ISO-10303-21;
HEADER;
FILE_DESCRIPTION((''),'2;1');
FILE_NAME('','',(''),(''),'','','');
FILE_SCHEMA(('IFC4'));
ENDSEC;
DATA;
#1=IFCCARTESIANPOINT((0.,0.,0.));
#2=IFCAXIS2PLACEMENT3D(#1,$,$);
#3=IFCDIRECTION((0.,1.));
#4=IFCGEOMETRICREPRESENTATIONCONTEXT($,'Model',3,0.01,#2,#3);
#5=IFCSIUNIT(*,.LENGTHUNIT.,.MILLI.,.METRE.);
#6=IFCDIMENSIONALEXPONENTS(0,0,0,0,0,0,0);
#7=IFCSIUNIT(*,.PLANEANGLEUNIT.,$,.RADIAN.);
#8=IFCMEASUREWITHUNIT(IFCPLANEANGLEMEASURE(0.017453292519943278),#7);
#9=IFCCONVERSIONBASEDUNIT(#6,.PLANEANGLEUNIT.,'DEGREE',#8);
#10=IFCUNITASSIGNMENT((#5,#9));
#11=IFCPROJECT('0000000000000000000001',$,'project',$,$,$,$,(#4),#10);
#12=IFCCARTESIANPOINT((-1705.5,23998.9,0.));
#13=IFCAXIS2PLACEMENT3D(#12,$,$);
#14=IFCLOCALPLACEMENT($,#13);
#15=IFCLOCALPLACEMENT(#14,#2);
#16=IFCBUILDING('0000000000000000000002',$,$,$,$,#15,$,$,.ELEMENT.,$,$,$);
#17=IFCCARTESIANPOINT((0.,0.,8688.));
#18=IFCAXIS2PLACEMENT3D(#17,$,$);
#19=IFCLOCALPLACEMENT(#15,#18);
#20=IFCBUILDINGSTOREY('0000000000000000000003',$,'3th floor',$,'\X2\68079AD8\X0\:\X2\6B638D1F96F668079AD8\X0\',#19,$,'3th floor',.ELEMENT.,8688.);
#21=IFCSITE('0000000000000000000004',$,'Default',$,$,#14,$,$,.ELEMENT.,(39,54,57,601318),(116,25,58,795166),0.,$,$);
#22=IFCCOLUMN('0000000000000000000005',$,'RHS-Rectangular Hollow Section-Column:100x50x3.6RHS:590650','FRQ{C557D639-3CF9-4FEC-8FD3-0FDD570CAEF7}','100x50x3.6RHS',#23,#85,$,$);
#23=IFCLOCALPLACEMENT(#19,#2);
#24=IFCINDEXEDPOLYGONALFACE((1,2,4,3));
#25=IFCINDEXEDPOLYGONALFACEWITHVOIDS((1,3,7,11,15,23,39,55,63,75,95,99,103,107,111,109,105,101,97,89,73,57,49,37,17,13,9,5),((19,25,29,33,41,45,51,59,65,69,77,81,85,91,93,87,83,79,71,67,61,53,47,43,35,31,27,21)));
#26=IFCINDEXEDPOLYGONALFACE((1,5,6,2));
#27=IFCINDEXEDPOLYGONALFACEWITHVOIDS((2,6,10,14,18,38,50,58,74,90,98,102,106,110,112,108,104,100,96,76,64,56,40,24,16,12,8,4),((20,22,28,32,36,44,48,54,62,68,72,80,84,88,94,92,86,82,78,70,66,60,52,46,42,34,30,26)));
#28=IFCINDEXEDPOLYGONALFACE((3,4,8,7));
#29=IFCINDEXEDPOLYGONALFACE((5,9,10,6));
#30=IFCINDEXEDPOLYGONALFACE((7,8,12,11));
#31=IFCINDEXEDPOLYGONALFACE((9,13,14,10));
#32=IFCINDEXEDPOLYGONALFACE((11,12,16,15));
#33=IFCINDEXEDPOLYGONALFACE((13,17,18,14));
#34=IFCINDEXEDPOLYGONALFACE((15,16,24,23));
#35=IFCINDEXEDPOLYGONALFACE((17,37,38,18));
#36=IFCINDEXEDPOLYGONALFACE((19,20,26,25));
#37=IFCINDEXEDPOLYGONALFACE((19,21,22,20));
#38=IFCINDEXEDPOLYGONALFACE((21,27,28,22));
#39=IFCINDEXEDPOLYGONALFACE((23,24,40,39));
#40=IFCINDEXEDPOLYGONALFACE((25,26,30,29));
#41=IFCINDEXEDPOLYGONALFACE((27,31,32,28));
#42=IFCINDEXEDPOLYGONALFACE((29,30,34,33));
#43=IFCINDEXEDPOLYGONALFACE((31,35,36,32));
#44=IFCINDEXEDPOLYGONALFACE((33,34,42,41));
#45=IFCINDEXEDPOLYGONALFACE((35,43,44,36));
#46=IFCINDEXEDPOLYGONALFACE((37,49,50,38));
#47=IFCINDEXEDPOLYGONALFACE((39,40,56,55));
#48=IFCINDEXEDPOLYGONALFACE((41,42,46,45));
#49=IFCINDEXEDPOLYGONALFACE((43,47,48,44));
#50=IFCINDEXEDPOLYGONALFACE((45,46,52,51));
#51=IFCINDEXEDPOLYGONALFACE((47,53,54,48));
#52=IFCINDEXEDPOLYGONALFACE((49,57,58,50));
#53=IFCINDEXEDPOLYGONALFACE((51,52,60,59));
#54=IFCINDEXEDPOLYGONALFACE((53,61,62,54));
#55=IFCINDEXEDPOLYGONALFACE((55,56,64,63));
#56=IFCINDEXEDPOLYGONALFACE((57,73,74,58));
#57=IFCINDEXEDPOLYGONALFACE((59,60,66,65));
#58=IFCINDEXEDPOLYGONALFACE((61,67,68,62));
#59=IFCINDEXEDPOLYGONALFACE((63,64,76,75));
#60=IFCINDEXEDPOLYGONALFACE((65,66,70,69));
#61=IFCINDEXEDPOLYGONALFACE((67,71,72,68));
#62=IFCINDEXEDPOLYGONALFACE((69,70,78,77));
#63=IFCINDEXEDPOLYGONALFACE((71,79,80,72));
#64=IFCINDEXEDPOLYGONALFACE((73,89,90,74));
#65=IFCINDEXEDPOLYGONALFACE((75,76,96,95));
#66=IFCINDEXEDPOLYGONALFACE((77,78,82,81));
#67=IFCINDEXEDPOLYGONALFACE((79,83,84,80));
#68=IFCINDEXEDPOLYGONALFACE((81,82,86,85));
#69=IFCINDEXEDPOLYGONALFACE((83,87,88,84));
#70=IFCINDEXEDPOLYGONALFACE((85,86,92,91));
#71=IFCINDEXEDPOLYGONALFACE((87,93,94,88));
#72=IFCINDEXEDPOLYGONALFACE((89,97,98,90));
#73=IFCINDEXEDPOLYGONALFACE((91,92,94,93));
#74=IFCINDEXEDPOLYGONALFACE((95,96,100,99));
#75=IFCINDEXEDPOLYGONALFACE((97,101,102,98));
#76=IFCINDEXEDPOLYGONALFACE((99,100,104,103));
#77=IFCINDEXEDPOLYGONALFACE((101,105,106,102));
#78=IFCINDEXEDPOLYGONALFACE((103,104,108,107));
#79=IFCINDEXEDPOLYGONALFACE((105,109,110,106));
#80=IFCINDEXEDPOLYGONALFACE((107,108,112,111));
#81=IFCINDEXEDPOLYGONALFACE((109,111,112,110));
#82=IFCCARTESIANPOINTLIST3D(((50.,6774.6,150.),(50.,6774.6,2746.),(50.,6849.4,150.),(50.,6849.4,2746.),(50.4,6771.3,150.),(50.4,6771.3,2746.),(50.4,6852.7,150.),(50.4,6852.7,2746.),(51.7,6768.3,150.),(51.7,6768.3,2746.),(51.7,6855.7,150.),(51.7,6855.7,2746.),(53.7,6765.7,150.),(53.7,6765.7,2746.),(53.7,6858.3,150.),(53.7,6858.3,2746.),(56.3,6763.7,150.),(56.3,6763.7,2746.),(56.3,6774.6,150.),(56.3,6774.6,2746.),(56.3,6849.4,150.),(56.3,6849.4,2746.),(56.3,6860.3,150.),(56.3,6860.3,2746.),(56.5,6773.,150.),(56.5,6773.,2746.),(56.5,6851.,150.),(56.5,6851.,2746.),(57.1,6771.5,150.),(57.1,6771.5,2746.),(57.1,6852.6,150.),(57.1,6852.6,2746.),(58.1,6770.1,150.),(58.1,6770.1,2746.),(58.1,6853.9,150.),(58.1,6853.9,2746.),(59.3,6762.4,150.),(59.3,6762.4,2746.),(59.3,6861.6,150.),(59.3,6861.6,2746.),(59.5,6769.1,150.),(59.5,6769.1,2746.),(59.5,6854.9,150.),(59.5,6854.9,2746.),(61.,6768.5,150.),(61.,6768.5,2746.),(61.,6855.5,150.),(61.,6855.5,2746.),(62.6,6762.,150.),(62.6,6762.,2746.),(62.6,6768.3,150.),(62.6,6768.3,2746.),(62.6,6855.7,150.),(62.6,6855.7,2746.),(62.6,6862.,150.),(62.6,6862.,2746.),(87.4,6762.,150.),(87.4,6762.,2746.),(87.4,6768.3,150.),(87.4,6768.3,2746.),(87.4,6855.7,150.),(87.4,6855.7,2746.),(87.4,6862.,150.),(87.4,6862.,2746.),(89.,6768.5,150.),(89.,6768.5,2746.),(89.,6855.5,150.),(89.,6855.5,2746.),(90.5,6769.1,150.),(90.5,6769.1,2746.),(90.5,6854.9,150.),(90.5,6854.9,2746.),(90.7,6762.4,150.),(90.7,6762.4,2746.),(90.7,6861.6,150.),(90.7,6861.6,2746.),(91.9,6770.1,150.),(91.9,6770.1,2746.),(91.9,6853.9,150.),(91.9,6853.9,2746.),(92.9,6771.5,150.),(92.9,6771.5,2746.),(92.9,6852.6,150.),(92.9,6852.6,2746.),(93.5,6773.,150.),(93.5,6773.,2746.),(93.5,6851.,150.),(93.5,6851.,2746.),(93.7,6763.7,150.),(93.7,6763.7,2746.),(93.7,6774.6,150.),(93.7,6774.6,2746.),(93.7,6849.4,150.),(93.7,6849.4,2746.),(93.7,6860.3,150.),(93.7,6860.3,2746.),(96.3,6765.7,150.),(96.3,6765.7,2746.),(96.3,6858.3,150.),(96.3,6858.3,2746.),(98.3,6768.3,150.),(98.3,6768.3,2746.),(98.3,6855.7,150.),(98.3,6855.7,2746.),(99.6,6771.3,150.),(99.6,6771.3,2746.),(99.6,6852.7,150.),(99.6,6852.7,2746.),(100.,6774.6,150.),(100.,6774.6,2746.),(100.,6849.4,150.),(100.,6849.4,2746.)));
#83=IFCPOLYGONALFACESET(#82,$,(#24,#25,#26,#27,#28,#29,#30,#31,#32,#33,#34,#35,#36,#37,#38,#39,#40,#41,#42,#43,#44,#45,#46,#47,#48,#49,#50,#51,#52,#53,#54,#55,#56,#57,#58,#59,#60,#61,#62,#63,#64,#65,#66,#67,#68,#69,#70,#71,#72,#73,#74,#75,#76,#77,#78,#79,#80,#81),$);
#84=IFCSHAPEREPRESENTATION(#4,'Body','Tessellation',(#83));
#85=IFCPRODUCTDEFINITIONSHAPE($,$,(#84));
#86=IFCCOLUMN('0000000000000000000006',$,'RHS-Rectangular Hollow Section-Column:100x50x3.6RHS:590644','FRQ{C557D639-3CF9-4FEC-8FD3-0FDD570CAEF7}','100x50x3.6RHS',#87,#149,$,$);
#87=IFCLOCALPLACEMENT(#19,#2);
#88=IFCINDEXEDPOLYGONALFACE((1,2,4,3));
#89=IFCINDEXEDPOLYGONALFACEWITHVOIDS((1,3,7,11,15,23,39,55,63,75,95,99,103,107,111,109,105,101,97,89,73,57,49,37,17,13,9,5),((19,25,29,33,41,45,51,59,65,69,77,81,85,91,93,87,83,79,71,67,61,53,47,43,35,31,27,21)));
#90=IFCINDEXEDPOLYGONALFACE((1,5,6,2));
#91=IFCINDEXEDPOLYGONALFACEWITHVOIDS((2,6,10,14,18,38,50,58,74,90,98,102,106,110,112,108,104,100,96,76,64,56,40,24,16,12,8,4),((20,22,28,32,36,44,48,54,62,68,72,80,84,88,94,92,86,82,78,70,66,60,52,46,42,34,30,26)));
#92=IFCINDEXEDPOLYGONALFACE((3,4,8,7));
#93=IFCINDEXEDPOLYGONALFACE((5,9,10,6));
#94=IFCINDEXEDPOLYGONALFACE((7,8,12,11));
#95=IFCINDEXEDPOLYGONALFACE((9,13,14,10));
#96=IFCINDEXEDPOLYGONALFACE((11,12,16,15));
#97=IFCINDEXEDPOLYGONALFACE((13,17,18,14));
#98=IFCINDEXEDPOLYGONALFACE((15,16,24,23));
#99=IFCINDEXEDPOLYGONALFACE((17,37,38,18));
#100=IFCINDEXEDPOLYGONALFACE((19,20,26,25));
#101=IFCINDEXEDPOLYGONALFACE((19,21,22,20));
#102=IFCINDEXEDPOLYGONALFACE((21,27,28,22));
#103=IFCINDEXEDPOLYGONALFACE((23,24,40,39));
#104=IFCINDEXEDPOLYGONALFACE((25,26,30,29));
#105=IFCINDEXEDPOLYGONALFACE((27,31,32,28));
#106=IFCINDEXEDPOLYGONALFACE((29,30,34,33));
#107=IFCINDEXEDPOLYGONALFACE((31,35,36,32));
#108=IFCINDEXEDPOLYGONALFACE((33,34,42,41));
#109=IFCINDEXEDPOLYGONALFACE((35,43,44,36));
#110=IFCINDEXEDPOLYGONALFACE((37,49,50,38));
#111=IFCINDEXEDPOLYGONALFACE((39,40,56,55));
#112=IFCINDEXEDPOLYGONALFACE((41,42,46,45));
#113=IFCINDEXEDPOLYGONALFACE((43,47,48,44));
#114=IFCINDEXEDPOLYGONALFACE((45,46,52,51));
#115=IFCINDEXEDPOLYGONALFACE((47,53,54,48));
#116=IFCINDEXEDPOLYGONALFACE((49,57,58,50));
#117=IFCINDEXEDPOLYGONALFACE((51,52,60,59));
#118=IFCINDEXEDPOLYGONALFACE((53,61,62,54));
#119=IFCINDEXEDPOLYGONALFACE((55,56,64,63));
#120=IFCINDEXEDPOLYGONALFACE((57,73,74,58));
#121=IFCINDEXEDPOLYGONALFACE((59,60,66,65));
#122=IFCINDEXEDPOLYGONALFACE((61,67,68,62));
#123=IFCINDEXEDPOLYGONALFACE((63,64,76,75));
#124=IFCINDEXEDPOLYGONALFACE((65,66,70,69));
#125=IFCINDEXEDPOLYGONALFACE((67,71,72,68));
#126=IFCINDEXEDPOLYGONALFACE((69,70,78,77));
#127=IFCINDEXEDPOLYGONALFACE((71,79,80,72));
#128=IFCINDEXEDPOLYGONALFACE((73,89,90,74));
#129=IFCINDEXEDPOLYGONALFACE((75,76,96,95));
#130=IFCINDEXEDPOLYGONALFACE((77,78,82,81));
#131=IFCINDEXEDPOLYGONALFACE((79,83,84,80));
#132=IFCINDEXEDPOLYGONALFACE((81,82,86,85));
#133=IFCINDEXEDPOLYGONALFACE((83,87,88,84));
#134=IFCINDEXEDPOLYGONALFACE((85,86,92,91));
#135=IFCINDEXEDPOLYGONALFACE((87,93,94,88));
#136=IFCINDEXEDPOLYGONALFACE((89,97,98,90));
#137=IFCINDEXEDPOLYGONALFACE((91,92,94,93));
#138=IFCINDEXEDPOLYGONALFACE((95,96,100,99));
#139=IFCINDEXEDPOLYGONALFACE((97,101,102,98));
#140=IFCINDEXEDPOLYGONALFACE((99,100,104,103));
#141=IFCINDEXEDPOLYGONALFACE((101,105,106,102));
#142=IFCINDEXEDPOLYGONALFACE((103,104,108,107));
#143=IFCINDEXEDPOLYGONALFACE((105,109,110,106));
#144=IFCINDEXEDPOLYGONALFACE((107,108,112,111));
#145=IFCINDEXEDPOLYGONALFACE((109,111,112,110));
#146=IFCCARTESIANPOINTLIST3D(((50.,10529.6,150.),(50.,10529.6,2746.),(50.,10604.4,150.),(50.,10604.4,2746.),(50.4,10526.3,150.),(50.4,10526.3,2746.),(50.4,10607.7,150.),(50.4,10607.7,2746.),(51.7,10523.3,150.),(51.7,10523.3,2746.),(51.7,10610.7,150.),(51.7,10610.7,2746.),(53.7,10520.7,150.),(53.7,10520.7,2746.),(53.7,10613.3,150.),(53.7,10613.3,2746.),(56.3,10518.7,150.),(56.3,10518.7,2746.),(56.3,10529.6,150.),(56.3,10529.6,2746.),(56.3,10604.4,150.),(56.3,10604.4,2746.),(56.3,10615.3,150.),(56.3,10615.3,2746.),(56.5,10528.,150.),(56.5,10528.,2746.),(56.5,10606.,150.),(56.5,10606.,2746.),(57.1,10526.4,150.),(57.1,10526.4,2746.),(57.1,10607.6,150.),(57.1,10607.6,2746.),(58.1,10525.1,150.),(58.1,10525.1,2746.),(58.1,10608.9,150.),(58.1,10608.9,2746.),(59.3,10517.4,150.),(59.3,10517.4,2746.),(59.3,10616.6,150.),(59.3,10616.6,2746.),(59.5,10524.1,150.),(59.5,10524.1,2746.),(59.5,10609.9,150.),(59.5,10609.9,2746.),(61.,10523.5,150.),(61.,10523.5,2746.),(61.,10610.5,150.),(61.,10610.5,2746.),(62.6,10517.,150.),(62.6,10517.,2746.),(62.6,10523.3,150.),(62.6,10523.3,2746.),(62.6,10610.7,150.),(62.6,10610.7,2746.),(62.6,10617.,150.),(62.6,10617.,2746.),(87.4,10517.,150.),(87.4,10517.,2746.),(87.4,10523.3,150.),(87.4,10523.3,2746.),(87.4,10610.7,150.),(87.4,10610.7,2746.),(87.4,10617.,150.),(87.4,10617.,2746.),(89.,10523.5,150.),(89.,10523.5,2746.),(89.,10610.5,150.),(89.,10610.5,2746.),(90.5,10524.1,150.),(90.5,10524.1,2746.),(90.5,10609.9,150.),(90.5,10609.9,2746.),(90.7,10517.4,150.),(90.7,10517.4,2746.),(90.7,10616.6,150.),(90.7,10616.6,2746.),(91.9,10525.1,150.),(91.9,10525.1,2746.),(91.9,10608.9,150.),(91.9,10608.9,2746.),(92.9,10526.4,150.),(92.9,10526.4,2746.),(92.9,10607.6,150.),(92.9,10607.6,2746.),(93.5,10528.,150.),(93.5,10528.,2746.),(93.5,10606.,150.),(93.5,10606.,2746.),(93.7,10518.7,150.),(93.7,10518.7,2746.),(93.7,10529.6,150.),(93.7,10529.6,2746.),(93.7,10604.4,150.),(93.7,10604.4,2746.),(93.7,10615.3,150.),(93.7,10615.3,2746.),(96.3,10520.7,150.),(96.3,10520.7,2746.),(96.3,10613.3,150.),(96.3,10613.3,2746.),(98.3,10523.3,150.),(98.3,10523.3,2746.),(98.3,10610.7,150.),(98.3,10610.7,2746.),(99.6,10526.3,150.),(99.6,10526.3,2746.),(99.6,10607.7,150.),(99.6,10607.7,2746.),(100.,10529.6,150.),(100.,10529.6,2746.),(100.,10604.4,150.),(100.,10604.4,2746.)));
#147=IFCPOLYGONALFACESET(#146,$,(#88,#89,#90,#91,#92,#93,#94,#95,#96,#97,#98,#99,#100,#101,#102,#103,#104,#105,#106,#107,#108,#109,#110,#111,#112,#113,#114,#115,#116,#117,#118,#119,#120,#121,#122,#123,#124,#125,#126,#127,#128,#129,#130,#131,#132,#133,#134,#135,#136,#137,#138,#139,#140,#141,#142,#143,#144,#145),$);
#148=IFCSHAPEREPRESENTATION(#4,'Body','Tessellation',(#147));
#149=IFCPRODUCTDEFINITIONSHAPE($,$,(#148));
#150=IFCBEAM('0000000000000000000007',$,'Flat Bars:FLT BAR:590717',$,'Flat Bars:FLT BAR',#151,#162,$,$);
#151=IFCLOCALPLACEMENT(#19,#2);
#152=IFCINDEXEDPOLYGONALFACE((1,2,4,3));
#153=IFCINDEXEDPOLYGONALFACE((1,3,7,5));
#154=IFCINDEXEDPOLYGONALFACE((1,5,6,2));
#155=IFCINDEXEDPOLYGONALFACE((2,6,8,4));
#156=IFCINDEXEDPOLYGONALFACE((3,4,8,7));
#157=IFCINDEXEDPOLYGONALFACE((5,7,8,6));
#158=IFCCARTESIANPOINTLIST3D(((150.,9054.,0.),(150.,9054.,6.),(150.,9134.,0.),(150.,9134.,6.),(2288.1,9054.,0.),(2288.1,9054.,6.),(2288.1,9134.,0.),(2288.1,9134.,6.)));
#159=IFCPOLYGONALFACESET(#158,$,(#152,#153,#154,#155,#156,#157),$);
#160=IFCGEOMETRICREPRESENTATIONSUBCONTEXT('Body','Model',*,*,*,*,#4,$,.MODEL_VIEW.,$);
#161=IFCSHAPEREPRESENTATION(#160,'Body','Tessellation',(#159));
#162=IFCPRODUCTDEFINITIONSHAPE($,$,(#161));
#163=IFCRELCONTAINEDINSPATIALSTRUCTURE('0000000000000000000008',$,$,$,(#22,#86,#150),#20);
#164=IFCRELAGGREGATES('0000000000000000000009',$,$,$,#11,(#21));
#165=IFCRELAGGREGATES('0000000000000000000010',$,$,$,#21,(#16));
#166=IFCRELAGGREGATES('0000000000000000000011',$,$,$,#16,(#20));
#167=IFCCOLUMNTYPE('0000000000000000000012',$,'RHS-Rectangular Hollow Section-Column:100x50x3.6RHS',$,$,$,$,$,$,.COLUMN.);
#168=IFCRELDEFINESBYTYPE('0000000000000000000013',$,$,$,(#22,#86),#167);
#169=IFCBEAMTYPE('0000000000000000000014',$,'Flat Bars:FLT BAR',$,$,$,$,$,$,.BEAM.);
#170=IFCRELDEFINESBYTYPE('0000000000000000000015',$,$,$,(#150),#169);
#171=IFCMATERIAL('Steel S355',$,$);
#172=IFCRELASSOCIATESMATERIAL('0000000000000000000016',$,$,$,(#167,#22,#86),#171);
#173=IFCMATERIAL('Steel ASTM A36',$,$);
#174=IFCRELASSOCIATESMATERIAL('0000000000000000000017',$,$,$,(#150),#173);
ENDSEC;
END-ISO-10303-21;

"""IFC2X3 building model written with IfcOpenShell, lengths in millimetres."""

from ifc_helpers import new_model, entity, si_unit, converted_unit, point, direction, frame, frame_2d, origin, origin_2d, origin_2d_with_axis, place, context, subcontext, project, spatial, circle_curve, line_curve, trimmed, segment, composite_curve, rectangle, hollow_rectangle, outline, extrude, clip, halfspace, material, type_object, element, save


model = new_model("IFC2X3")

# Units and contexts
model_context = context("Model", 3, precision=0.01, world=origin(), true_north=direction((0.0, 1.0)))
body_context = subcontext(model_context, "Body", "Model", "MODEL_VIEW")
ifc_project = project(units=[si_unit("LENGTHUNIT", "METRE", prefix="MILLI"), converted_unit("PLANEANGLEUNIT", "DEGREE", entity("IfcPlaneAngleMeasure", 0.017453292519943278), si_unit("PLANEANGLEUNIT", "RADIAN"), dimensions=[0, 0, 0, 0, 0, 0, 0])], contexts=[model_context])

# Site, building, storey
site_placement = place(None, frame((-1705.5, 23998.9, 0.0)))
site = spatial("IfcSite", under=ifc_project, at=site_placement, Name="Default", CompositionType="ELEMENT", RefLatitude=(39, 54, 57, 601318), RefLongitude=(116, 25, 58, 795166), RefElevation=0.0)
building_placement = place(site_placement, origin())
building = spatial("IfcBuilding", under=site, at=building_placement, CompositionType="ELEMENT")
storey_placement = place(building_placement, frame((0.0, 0.0, 8688.0)))
storey = spatial("IfcBuildingStorey", under=building, at=storey_placement, Name="3th floor", ObjectType="标高:正负零标高", LongName="3th floor", CompositionType="ELEMENT", Elevation=8688.0)

# Shared definitions
ifc_material_1 = material(Name="Steel S355")

# Columns, openings
column_type_1 = type_object("IfcColumnType", Name="RHS-Rectangular Hollow Section-Column:100x50x3.6RHS", PredefinedType="COLUMN", material=ifc_material_1)
column_1_placement = place(storey_placement, frame((75.0, 6812.0, 2876.9)))
column_1 = element("IfcColumn", 1, at=column_1_placement, inside=storey, type_object=column_type_1, material=ifc_material_1, Name="RHS-Rectangular Hollow Section-Column:100x50x3.6RHS:590650", Description="FRQ{C557D639-3CF9-4FEC-8FD3-0FDD570CAEF7}", ObjectType="100x50x3.6RHS", context=model_context, shape_type="Clipping", body=[
    clip(clip(extrude(hollow_rectangle(XDim=50.0, YDim=100.0, WallThickness=6.3, InnerFilletRadius=6.3, OuterFilletRadius=12.6, at=origin_2d()), origin(), (0.0, 0.0, -1.0), 2782.8), halfspace(frame((-75.0, -6812.0, -2726.9), z_axis=(0.0, 0.0, 1.0), x_axis=(1.0, 0.0, 0.0)), True)), halfspace(frame((-75.0, -6812.0, -55.9), z_axis=(0.0, 0.0, -1.0), x_axis=(-1.0, 0.0, 0.0)), True)),
])
opening_1_placement = place(column_1_placement, frame((0.0, -150.1, -130.9), z_axis=(0.0, 1.0, 0.0), x_axis=(-1.0, 0.0, 0.0)))
element("IfcOpeningElement", 2, at=opening_1_placement, cuts=column_1, ObjectType="Opening", context=model_context, shape_type="SweptSolid", body=[
    extrude(outline(composite_curve([segment(trimmed(circle_curve(frame_2d((43.0, 32.0), x_axis=(1.0, 0.0)), 32.0), [point((43.0, 0.0))], [point((75.0, 32.0))], True, "CARTESIAN"), True, "CONTINUOUS"), segment(trimmed(line_curve((75.0, 32.0), (0.0, 1.0), 86.0), [point((75.0, 32.0))], [point((75.0, 118.0))], True, "CARTESIAN"), True, "CONTINUOUS"), segment(trimmed(circle_curve(frame_2d((43.0, 118.0), x_axis=(1.0, 0.0)), 32.0), [point((75.0, 118.0))], [point((43.0, 150.0))], True, "CARTESIAN"), True, "CONTINUOUS"), segment(trimmed(line_curve((43.0, 150.0), (-1.0, 0.0), 86.0), [point((43.0, 150.0))], [point((-43.0, 150.0))], True, "CARTESIAN"), True, "CONTINUOUS"), segment(trimmed(circle_curve(frame_2d((-43.0, 118.0), x_axis=(1.0, 0.0)), 32.0), [point((-43.0, 150.0))], [point((-75.0, 118.0))], True, "CARTESIAN"), True, "CONTINUOUS"), segment(trimmed(line_curve((-75.0, 118.0), (0.0, -1.0), 86.0), [point((-75.0, 118.0))], [point((-75.0, 32.0))], True, "CARTESIAN"), True, "CONTINUOUS"), segment(trimmed(circle_curve(frame_2d((-43.0, 32.0), x_axis=(1.0, 0.0)), 32.0), [point((-75.0, 32.0))], [point((-43.0, 0.0))], True, "CARTESIAN"), True, "CONTINUOUS"), segment(trimmed(line_curve((-43.0, 0.0), (1.0, 0.0), 86.0), [point((-43.0, 0.0))], [point((43.0, 0.0))], True, "CARTESIAN"), True, "CONTINUOUS")], self_intersect="UNKNOWN")), origin(), (0.0, 0.0, 1.0), 300.2),
])
column_2_placement = place(storey_placement, frame((75.0, 10567.0, 2876.9)))
column_2 = element("IfcColumn", 3, at=column_2_placement, inside=storey, type_object=column_type_1, material=ifc_material_1, Name="RHS-Rectangular Hollow Section-Column:100x50x3.6RHS:590644", Description="FRQ{C557D639-3CF9-4FEC-8FD3-0FDD570CAEF7}", ObjectType="100x50x3.6RHS", context=model_context, shape_type="Clipping", body=[
    clip(clip(extrude(hollow_rectangle(XDim=50.0, YDim=100.0, WallThickness=6.3, InnerFilletRadius=6.3, OuterFilletRadius=12.6, at=origin_2d()), origin(), (0.0, 0.0, -1.0), 2782.8), halfspace(frame((-75.0, -10567.0, -55.9), z_axis=(0.0, 0.0, -1.0), x_axis=(-1.0, 0.0, 0.0)), True)), halfspace(frame((-75.0, -10567.0, -2726.9), z_axis=(0.0, 0.0, 1.0), x_axis=(1.0, 0.0, 0.0)), True)),
])
opening_2_placement = place(column_2_placement, frame((0.0, -150.1, -130.9), z_axis=(0.0, 1.0, 0.0), x_axis=(-1.0, 0.0, 0.0)))
element("IfcOpeningElement", 4, at=opening_2_placement, cuts=column_2, ObjectType="Opening", context=model_context, shape_type="SweptSolid", body=[
    extrude(outline(composite_curve([segment(trimmed(circle_curve(frame_2d((43.0, 32.0), x_axis=(1.0, 0.0)), 32.0), [point((43.0, 0.0))], [point((75.0, 32.0))], True, "CARTESIAN"), True, "CONTINUOUS"), segment(trimmed(line_curve((75.0, 32.0), (0.0, 1.0), 86.0), [point((75.0, 32.0))], [point((75.0, 118.0))], True, "CARTESIAN"), True, "CONTINUOUS"), segment(trimmed(circle_curve(frame_2d((43.0, 118.0), x_axis=(1.0, 0.0)), 32.0), [point((75.0, 118.0))], [point((43.0, 150.0))], True, "CARTESIAN"), True, "CONTINUOUS"), segment(trimmed(line_curve((43.0, 150.0), (-1.0, 0.0), 86.0), [point((43.0, 150.0))], [point((-43.0, 150.0))], True, "CARTESIAN"), True, "CONTINUOUS"), segment(trimmed(circle_curve(frame_2d((-43.0, 118.0), x_axis=(1.0, 0.0)), 32.0), [point((-43.0, 150.0))], [point((-75.0, 118.0))], True, "CARTESIAN"), True, "CONTINUOUS"), segment(trimmed(line_curve((-75.0, 118.0), (0.0, -1.0), 86.0), [point((-75.0, 118.0))], [point((-75.0, 32.0))], True, "CARTESIAN"), True, "CONTINUOUS"), segment(trimmed(circle_curve(frame_2d((-43.0, 32.0), x_axis=(1.0, 0.0)), 32.0), [point((-75.0, 32.0))], [point((-43.0, 0.0))], True, "CARTESIAN"), True, "CONTINUOUS"), segment(trimmed(line_curve((-43.0, 0.0), (1.0, 0.0), 86.0), [point((-43.0, 0.0))], [point((43.0, 0.0))], True, "CARTESIAN"), True, "CONTINUOUS")], self_intersect="UNKNOWN")), origin(), (0.0, 0.0, 1.0), 300.2),
])

# Beam
ifc_material_2 = material(Name="Steel ASTM A36")
beam_type = type_object("IfcBeamType", Name="Flat Bars:FLT BAR", PredefinedType="BEAM")
for number, where, name in (
    (5, (150.0, 9094.0, 6.0), "Flat Bars:FLT BAR:590717"),
):
    element("IfcBeam", number, at=place(storey_placement, frame(where)), inside=storey, type_object=beam_type, material=ifc_material_2, Name=name, ObjectType="Flat Bars:FLT BAR", context=body_context, shape_type="SweptSolid", body=[
        extrude(rectangle(XDim=6.0, YDim=80.0, at=origin_2d_with_axis()), frame((0.0, 0.0, -3.0), z_axis=(1.0, 0.0, 0.0), x_axis=(0.0, 0.0, -1.0)), (0.0, 0.0, 1.0), 2138.1),
    ])

save(model, "model.ifc")
